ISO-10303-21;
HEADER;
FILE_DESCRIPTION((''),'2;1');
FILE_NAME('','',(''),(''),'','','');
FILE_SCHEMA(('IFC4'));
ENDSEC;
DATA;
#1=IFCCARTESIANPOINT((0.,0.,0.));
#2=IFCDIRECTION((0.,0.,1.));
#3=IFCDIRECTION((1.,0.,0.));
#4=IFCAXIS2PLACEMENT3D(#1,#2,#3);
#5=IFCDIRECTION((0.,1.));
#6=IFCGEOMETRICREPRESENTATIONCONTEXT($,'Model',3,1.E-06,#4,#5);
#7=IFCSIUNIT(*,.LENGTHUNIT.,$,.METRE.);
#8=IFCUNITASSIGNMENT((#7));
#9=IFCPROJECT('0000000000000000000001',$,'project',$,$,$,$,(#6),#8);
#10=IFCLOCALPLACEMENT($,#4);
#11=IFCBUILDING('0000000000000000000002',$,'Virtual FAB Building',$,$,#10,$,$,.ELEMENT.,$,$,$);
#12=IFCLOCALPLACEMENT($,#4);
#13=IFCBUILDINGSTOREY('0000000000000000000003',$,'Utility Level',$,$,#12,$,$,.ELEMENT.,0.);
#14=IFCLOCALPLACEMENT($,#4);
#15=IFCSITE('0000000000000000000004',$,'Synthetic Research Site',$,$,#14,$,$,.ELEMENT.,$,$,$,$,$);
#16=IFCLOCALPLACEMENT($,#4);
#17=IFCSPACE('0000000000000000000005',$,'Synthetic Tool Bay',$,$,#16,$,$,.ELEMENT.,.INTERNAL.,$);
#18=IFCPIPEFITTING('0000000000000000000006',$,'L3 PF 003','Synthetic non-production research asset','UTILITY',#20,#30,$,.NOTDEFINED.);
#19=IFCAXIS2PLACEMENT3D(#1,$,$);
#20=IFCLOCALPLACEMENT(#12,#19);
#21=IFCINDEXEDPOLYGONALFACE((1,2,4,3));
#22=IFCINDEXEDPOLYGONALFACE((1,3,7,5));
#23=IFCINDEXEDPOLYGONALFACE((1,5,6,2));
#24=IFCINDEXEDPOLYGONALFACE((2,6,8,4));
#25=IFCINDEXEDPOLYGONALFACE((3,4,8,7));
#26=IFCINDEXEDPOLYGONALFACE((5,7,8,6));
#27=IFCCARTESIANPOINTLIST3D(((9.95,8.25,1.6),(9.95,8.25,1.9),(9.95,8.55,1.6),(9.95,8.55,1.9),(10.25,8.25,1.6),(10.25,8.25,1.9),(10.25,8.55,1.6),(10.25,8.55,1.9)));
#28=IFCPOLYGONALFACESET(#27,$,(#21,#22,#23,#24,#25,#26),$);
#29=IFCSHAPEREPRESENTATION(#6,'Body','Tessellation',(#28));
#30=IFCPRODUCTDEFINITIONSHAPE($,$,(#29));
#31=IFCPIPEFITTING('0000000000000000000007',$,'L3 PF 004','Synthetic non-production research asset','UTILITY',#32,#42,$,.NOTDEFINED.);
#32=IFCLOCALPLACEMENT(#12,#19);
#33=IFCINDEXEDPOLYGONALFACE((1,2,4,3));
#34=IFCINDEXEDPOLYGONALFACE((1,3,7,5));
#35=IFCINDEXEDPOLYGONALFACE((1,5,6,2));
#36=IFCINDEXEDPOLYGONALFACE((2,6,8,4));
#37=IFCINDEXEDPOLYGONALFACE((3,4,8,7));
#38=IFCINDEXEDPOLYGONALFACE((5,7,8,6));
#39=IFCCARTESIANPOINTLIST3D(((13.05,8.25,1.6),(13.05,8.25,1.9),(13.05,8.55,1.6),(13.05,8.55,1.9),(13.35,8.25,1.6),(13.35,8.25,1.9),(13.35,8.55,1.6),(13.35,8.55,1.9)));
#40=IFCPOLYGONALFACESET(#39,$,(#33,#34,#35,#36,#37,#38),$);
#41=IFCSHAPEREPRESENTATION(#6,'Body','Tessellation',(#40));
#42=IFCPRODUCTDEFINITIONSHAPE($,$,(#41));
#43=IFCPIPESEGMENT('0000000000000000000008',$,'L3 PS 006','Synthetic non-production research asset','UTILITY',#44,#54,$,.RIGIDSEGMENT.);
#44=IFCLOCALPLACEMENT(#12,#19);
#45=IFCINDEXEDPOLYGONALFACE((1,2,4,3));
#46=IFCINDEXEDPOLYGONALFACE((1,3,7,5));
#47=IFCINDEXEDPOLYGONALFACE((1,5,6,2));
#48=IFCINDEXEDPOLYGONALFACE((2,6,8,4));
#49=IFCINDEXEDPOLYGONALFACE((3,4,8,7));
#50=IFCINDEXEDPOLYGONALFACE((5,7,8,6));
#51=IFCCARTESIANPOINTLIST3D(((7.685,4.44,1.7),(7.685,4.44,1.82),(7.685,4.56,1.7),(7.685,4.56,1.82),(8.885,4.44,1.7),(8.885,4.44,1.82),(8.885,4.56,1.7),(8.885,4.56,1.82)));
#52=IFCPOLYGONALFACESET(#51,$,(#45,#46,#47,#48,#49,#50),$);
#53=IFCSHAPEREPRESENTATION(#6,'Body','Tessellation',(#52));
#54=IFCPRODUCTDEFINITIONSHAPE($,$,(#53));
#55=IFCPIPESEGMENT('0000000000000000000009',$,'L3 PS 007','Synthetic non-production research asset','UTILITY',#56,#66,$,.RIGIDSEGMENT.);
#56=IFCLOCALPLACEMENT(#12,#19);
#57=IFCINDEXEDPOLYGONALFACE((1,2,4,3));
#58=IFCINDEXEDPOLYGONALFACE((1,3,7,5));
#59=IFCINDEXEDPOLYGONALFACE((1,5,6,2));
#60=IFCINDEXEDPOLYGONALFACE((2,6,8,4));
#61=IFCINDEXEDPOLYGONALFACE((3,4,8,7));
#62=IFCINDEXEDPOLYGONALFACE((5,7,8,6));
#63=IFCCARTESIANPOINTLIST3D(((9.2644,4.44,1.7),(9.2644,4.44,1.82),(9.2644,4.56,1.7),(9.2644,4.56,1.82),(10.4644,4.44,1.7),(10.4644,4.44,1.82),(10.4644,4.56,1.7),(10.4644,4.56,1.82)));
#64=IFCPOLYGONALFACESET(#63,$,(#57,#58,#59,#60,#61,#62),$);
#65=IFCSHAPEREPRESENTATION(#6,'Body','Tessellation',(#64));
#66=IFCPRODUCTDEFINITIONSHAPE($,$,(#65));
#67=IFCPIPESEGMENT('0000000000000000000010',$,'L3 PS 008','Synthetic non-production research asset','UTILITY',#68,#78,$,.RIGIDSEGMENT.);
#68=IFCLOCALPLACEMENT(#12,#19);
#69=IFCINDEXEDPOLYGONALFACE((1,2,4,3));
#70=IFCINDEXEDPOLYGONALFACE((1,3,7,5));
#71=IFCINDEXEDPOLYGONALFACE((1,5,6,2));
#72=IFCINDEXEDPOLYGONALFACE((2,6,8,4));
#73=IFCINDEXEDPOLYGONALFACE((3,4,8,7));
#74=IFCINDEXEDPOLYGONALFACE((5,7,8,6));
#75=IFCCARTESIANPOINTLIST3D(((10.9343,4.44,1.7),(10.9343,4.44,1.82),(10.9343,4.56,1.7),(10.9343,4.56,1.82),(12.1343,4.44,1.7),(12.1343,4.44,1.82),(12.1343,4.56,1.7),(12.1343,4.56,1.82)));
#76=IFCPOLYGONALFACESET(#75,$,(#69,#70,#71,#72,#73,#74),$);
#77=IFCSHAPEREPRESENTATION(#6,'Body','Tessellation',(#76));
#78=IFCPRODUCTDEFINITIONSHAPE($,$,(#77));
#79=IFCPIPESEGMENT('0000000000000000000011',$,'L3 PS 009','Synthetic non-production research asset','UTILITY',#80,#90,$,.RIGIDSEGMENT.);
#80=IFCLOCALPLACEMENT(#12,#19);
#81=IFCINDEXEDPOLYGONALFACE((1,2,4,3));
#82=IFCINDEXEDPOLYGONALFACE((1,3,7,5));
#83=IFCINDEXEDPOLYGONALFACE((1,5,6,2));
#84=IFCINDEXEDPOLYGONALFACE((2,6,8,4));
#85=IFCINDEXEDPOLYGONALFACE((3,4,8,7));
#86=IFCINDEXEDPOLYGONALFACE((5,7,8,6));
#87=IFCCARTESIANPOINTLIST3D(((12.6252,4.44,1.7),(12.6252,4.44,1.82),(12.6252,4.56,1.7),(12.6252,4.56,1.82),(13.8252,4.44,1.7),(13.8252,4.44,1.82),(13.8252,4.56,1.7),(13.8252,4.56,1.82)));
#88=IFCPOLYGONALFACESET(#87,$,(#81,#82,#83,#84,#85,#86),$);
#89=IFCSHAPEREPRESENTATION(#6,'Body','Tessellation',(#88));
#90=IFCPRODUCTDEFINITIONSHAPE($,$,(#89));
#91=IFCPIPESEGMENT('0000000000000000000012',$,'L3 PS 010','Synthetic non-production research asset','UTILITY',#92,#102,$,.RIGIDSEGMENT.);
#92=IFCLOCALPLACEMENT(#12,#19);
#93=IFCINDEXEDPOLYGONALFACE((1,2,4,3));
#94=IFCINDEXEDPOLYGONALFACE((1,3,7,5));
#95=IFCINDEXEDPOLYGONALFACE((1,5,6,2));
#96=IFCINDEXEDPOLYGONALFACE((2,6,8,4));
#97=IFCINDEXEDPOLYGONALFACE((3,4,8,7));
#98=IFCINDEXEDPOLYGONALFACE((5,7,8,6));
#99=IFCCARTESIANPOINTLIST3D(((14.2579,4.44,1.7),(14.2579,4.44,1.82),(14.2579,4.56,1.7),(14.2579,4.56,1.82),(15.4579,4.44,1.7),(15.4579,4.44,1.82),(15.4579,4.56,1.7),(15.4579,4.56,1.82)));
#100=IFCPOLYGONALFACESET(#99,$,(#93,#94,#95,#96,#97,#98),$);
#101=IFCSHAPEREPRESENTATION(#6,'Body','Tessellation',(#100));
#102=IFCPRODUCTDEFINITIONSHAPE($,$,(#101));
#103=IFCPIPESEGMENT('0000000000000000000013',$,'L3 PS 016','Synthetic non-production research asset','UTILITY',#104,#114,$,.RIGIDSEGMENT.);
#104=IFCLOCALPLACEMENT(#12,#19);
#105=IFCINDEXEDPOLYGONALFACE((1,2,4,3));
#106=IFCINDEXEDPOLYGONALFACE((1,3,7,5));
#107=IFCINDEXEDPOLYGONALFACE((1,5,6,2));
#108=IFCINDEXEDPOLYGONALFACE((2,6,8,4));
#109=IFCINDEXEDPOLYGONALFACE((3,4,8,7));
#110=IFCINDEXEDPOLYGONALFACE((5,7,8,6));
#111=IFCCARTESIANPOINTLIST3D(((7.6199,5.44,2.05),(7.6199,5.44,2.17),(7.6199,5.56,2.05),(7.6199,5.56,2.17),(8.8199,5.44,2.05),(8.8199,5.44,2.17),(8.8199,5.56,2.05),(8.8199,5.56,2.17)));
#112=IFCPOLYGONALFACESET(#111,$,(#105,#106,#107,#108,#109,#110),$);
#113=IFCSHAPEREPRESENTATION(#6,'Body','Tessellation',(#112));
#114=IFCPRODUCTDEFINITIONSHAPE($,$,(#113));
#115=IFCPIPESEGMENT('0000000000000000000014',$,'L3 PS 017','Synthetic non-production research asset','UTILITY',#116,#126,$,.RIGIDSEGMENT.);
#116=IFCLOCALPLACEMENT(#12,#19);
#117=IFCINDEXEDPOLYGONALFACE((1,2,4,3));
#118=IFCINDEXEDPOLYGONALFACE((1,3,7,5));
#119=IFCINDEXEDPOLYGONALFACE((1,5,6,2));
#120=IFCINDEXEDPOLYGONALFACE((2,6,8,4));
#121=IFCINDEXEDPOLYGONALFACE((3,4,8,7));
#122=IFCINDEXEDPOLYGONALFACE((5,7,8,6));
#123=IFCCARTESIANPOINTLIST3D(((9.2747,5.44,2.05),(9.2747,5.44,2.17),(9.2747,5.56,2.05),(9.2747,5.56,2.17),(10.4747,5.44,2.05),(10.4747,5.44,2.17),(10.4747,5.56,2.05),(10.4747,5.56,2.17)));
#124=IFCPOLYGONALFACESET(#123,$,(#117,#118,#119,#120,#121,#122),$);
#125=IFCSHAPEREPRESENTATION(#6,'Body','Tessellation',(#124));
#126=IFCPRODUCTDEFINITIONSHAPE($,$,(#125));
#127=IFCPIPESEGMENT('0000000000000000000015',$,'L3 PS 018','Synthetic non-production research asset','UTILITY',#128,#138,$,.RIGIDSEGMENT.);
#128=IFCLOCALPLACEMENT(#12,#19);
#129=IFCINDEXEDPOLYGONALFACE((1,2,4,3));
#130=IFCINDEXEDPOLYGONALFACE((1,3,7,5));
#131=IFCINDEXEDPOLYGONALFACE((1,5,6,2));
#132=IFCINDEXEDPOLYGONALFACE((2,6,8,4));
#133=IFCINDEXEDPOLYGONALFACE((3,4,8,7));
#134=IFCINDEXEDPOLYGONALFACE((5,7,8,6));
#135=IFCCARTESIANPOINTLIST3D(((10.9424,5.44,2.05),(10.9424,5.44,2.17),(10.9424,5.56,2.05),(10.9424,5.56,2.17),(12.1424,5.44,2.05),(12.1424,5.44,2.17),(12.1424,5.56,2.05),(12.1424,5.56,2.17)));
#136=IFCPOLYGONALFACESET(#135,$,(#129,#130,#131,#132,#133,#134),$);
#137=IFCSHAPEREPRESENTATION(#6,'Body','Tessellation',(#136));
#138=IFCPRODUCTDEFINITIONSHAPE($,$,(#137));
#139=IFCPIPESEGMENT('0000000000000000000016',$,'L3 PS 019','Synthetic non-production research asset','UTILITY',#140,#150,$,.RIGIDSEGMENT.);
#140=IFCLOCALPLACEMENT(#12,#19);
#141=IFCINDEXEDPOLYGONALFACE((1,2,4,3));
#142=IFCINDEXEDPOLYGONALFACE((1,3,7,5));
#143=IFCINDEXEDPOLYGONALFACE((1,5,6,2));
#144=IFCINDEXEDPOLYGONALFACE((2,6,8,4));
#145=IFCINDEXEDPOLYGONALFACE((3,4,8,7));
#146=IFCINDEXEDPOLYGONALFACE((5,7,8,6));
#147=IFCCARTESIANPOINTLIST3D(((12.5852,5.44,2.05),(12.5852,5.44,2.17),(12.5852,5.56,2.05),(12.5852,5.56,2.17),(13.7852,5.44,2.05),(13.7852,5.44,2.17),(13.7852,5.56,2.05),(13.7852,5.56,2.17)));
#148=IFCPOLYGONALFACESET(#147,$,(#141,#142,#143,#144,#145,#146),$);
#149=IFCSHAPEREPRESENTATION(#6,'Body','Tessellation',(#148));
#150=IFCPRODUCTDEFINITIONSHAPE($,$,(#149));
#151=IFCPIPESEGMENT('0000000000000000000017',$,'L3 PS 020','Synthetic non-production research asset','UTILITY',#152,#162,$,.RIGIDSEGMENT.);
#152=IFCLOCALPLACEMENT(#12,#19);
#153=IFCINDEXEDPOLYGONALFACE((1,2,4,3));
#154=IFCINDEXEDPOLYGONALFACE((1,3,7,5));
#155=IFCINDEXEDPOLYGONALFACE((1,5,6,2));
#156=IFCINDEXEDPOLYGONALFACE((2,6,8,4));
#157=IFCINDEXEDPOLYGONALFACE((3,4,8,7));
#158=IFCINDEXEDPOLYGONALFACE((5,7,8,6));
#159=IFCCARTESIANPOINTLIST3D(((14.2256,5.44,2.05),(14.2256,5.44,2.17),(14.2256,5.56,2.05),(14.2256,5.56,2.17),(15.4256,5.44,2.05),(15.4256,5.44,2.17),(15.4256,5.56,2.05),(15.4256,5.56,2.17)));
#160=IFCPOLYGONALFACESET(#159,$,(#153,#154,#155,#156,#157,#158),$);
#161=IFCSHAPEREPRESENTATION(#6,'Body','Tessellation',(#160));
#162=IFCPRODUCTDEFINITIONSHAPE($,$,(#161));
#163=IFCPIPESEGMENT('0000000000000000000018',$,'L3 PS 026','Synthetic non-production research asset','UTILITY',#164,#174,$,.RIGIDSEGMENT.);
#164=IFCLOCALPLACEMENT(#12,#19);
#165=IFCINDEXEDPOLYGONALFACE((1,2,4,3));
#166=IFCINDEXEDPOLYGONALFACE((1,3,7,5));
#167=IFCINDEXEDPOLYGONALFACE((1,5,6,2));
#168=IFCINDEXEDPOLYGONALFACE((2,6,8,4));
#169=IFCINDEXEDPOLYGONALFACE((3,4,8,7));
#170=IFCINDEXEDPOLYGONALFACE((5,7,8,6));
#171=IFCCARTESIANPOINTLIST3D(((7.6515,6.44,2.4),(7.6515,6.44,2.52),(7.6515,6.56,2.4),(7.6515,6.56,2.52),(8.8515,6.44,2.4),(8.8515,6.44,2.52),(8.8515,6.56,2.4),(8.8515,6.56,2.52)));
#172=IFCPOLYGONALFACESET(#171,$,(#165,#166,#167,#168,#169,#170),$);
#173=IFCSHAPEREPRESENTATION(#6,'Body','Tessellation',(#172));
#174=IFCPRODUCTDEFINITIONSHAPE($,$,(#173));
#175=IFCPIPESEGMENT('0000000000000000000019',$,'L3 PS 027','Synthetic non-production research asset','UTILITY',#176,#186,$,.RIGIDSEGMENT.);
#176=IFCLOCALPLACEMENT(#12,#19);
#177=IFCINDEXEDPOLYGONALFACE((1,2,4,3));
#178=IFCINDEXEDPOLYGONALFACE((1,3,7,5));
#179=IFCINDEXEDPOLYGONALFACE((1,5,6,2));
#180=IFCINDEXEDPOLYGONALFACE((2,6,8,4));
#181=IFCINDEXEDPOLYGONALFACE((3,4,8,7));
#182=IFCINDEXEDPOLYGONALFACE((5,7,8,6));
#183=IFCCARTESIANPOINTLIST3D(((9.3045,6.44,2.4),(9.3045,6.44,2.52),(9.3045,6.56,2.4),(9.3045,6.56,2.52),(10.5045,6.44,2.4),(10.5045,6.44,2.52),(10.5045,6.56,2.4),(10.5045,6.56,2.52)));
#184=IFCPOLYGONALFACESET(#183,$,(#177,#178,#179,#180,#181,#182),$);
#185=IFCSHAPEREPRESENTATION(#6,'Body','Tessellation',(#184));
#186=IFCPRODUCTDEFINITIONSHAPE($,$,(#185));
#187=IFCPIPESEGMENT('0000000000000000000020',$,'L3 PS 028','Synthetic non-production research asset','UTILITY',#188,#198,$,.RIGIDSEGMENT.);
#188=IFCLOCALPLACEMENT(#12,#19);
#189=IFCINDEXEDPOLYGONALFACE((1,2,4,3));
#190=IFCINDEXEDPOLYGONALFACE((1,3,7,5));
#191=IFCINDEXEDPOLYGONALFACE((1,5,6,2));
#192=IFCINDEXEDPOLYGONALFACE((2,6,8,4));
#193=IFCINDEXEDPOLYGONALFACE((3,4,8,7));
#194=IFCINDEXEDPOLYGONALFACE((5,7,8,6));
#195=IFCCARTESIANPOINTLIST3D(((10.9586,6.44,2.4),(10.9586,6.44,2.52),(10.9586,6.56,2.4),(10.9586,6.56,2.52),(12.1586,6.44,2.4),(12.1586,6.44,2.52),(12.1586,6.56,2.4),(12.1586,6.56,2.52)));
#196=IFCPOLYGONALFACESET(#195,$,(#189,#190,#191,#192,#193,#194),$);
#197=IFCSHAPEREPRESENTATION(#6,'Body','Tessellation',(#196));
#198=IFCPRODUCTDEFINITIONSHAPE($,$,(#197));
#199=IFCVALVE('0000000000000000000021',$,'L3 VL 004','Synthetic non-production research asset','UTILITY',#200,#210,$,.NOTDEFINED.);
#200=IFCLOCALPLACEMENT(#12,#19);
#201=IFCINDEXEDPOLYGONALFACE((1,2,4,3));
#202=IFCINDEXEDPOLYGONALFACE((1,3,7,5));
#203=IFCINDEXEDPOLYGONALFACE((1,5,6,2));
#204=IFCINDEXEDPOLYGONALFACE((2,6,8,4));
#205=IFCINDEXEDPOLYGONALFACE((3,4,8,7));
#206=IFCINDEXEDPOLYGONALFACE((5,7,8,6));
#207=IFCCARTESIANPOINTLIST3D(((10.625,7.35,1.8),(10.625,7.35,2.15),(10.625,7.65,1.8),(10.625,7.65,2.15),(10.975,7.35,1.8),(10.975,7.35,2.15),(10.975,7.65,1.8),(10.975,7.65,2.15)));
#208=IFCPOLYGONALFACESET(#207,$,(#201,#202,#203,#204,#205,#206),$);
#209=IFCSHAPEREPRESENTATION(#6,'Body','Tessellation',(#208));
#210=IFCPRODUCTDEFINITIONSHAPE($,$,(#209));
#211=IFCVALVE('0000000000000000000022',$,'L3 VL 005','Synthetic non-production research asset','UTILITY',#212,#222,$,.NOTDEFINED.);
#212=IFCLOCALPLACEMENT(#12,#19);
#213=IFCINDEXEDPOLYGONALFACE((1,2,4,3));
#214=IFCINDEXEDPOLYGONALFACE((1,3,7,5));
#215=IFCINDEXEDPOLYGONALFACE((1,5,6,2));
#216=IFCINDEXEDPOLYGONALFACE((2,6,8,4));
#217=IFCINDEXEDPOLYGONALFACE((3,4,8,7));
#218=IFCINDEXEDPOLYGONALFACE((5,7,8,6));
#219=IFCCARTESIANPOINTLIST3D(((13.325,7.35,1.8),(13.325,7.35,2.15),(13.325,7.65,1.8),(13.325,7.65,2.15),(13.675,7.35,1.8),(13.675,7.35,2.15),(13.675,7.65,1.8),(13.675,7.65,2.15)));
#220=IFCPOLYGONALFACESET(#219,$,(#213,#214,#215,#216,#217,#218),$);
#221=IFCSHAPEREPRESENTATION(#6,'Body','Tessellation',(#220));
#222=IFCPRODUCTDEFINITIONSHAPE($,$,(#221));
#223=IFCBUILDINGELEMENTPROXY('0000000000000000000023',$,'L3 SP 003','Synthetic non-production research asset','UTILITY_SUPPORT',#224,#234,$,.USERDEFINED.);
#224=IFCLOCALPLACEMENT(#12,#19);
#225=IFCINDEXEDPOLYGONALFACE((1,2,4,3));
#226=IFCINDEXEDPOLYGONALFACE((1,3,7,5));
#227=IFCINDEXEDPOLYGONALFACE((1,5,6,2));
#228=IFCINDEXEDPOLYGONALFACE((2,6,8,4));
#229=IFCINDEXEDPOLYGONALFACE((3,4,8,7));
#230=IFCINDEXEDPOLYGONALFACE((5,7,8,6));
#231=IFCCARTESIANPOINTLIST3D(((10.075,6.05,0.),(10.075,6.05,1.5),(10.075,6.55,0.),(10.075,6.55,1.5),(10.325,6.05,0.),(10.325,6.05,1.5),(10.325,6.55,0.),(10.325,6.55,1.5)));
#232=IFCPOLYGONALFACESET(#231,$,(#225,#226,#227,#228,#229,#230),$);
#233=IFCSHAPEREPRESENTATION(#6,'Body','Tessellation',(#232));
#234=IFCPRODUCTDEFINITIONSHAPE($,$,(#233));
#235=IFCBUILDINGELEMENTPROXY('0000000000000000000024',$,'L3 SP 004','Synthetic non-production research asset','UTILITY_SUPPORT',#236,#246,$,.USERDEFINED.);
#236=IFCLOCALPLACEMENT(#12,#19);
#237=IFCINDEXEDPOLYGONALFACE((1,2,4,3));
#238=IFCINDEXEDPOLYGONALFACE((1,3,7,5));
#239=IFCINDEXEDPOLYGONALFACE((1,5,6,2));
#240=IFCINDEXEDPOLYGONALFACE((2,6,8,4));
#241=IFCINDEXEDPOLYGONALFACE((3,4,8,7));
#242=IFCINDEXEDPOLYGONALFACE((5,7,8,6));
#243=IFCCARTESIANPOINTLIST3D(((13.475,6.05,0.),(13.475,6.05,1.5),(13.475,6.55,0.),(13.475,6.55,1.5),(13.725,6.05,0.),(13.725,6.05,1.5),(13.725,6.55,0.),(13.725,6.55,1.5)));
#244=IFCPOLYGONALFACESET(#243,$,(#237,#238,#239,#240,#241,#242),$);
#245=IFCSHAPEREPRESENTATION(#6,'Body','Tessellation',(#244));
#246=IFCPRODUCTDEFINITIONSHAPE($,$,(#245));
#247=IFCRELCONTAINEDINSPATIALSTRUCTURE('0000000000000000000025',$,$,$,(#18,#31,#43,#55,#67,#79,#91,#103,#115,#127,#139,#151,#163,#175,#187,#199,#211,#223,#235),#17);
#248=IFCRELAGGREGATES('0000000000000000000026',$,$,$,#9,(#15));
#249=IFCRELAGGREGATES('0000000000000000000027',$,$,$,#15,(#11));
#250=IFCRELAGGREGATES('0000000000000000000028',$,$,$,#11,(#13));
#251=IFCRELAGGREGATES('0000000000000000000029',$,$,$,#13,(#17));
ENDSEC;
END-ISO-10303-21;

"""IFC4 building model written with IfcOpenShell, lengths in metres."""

from ifc_helpers import new_model, si_unit, direction, frame, origin_with_axes, origin_2d_with_axis, place, context, project, spatial, rectangle, extrude, element, save


model = new_model("IFC4")

# Units and contexts
model_context = context("Model", 3, precision=1e-06, world=origin_with_axes(), true_north=direction((0.0, 1.0)))
ifc_project = project(units=[si_unit("LENGTHUNIT", "METRE")], contexts=[model_context])

# Site, building, storey, space
site_placement = place(None, origin_with_axes())
site = spatial("IfcSite", under=ifc_project, at=site_placement, Name="Synthetic Research Site", CompositionType="ELEMENT")
building_placement = place(None, origin_with_axes())
building = spatial("IfcBuilding", under=site, at=building_placement, Name="Virtual FAB Building", CompositionType="ELEMENT")
storey_placement = place(None, origin_with_axes())
storey = spatial("IfcBuildingStorey", under=building, at=storey_placement, Name="Utility Level", CompositionType="ELEMENT", Elevation=0.0)
space_placement = place(None, origin_with_axes())
space = spatial("IfcSpace", under=storey, at=space_placement, Name="Synthetic Tool Bay", CompositionType="ELEMENT", PredefinedType="INTERNAL")

# Pipe fittings
for number, where, z_axis, x_axis, name in (
    (1, (10.1, 8.4, 1.6), (0.0, 0.0, 1.0), (1.0, 0.0, 0.0), "L3 PF 003"),
    (2, (13.2, 8.4, 1.6), (0.0, 0.0, 1.0), (1.0, 0.0, 0.0), "L3 PF 004"),
):
    element("IfcPipeFitting", number, at=place(None, frame(where, z_axis=z_axis, x_axis=x_axis)), inside=space, Name=name, Description="Synthetic non-production research asset", ObjectType="UTILITY", PredefinedType="NOTDEFINED", context=model_context, shape_type="SweptSolid", body=[
        extrude(rectangle(XDim=0.3, YDim=0.3, at=origin_2d_with_axis()), origin_with_axes(), (0.0, 0.0, 1.0), 0.3),
    ])

# Pipe segments
for number, where, z_axis, x_axis, name in (
    (3, (8.285, 4.5, 1.7), (0.0, 0.0, 1.0), (1.0, 0.0, 0.0), "L3 PS 006"),
    (4, (9.8644, 4.5, 1.7), (0.0, 0.0, 1.0), (1.0, 0.0, 0.0), "L3 PS 007"),
    (5, (11.5343, 4.5, 1.7), (0.0, 0.0, 1.0), (1.0, 0.0, 0.0), "L3 PS 008"),
    (6, (13.2252, 4.5, 1.7), (0.0, 0.0, 1.0), (1.0, 0.0, 0.0), "L3 PS 009"),
    (7, (14.8579, 4.5, 1.7), (0.0, 0.0, 1.0), (1.0, 0.0, 0.0), "L3 PS 010"),
    (8, (8.2199, 5.5, 2.05), (0.0, 0.0, 1.0), (1.0, 0.0, 0.0), "L3 PS 016"),
    (9, (9.8747, 5.5, 2.05), (0.0, 0.0, 1.0), (1.0, 0.0, 0.0), "L3 PS 017"),
    (10, (11.5424, 5.5, 2.05), (0.0, 0.0, 1.0), (1.0, 0.0, 0.0), "L3 PS 018"),
    (11, (13.1852, 5.5, 2.05), (0.0, 0.0, 1.0), (1.0, 0.0, 0.0), "L3 PS 019"),
    (12, (14.8256, 5.5, 2.05), (0.0, 0.0, 1.0), (1.0, 0.0, 0.0), "L3 PS 020"),
    (13, (8.2515, 6.5, 2.4), (0.0, 0.0, 1.0), (1.0, 0.0, 0.0), "L3 PS 026"),
    (14, (9.9045, 6.5, 2.4), (0.0, 0.0, 1.0), (1.0, 0.0, 0.0), "L3 PS 027"),
    (15, (11.5586, 6.5, 2.4), (0.0, 0.0, 1.0), (1.0, 0.0, 0.0), "L3 PS 028"),
):
    element("IfcPipeSegment", number, at=place(None, frame(where, z_axis=z_axis, x_axis=x_axis)), inside=space, Name=name, Description="Synthetic non-production research asset", ObjectType="UTILITY", PredefinedType="RIGIDSEGMENT", context=model_context, shape_type="SweptSolid", body=[
        extrude(rectangle(XDim=1.2, YDim=0.12, at=origin_2d_with_axis()), origin_with_axes(), (0.0, 0.0, 1.0), 0.12),
    ])

# Valves
for number, where, z_axis, x_axis, name in (
    (16, (10.8, 7.5, 1.8), (0.0, 0.0, 1.0), (1.0, 0.0, 0.0), "L3 VL 004"),
    (17, (13.5, 7.5, 1.8), (0.0, 0.0, 1.0), (1.0, 0.0, 0.0), "L3 VL 005"),
):
    element("IfcValve", number, at=place(None, frame(where, z_axis=z_axis, x_axis=x_axis)), inside=space, Name=name, Description="Synthetic non-production research asset", ObjectType="UTILITY", PredefinedType="NOTDEFINED", context=model_context, shape_type="SweptSolid", body=[
        extrude(rectangle(XDim=0.35, YDim=0.3, at=origin_2d_with_axis()), origin_with_axes(), (0.0, 0.0, 1.0), 0.35),
    ])

# Building element proxies
for number, where, z_axis, x_axis, name in (
    (18, (10.2, 6.3, 0.0), (0.0, 0.0, 1.0), (1.0, 0.0, 0.0), "L3 SP 003"),
    (19, (13.6, 6.3, 0.0), (0.0, 0.0, 1.0), (1.0, 0.0, 0.0), "L3 SP 004"),
):
    element("IfcBuildingElementProxy", number, at=place(None, frame(where, z_axis=z_axis, x_axis=x_axis)), inside=space, Name=name, Description="Synthetic non-production research asset", ObjectType="UTILITY_SUPPORT", PredefinedType="USERDEFINED", context=model_context, shape_type="SweptSolid", body=[
        extrude(rectangle(XDim=0.25, YDim=0.5, at=origin_2d_with_axis()), origin_with_axes(), (0.0, 0.0, 1.0), 1.5),
    ])

save(model, "model.ifc")
